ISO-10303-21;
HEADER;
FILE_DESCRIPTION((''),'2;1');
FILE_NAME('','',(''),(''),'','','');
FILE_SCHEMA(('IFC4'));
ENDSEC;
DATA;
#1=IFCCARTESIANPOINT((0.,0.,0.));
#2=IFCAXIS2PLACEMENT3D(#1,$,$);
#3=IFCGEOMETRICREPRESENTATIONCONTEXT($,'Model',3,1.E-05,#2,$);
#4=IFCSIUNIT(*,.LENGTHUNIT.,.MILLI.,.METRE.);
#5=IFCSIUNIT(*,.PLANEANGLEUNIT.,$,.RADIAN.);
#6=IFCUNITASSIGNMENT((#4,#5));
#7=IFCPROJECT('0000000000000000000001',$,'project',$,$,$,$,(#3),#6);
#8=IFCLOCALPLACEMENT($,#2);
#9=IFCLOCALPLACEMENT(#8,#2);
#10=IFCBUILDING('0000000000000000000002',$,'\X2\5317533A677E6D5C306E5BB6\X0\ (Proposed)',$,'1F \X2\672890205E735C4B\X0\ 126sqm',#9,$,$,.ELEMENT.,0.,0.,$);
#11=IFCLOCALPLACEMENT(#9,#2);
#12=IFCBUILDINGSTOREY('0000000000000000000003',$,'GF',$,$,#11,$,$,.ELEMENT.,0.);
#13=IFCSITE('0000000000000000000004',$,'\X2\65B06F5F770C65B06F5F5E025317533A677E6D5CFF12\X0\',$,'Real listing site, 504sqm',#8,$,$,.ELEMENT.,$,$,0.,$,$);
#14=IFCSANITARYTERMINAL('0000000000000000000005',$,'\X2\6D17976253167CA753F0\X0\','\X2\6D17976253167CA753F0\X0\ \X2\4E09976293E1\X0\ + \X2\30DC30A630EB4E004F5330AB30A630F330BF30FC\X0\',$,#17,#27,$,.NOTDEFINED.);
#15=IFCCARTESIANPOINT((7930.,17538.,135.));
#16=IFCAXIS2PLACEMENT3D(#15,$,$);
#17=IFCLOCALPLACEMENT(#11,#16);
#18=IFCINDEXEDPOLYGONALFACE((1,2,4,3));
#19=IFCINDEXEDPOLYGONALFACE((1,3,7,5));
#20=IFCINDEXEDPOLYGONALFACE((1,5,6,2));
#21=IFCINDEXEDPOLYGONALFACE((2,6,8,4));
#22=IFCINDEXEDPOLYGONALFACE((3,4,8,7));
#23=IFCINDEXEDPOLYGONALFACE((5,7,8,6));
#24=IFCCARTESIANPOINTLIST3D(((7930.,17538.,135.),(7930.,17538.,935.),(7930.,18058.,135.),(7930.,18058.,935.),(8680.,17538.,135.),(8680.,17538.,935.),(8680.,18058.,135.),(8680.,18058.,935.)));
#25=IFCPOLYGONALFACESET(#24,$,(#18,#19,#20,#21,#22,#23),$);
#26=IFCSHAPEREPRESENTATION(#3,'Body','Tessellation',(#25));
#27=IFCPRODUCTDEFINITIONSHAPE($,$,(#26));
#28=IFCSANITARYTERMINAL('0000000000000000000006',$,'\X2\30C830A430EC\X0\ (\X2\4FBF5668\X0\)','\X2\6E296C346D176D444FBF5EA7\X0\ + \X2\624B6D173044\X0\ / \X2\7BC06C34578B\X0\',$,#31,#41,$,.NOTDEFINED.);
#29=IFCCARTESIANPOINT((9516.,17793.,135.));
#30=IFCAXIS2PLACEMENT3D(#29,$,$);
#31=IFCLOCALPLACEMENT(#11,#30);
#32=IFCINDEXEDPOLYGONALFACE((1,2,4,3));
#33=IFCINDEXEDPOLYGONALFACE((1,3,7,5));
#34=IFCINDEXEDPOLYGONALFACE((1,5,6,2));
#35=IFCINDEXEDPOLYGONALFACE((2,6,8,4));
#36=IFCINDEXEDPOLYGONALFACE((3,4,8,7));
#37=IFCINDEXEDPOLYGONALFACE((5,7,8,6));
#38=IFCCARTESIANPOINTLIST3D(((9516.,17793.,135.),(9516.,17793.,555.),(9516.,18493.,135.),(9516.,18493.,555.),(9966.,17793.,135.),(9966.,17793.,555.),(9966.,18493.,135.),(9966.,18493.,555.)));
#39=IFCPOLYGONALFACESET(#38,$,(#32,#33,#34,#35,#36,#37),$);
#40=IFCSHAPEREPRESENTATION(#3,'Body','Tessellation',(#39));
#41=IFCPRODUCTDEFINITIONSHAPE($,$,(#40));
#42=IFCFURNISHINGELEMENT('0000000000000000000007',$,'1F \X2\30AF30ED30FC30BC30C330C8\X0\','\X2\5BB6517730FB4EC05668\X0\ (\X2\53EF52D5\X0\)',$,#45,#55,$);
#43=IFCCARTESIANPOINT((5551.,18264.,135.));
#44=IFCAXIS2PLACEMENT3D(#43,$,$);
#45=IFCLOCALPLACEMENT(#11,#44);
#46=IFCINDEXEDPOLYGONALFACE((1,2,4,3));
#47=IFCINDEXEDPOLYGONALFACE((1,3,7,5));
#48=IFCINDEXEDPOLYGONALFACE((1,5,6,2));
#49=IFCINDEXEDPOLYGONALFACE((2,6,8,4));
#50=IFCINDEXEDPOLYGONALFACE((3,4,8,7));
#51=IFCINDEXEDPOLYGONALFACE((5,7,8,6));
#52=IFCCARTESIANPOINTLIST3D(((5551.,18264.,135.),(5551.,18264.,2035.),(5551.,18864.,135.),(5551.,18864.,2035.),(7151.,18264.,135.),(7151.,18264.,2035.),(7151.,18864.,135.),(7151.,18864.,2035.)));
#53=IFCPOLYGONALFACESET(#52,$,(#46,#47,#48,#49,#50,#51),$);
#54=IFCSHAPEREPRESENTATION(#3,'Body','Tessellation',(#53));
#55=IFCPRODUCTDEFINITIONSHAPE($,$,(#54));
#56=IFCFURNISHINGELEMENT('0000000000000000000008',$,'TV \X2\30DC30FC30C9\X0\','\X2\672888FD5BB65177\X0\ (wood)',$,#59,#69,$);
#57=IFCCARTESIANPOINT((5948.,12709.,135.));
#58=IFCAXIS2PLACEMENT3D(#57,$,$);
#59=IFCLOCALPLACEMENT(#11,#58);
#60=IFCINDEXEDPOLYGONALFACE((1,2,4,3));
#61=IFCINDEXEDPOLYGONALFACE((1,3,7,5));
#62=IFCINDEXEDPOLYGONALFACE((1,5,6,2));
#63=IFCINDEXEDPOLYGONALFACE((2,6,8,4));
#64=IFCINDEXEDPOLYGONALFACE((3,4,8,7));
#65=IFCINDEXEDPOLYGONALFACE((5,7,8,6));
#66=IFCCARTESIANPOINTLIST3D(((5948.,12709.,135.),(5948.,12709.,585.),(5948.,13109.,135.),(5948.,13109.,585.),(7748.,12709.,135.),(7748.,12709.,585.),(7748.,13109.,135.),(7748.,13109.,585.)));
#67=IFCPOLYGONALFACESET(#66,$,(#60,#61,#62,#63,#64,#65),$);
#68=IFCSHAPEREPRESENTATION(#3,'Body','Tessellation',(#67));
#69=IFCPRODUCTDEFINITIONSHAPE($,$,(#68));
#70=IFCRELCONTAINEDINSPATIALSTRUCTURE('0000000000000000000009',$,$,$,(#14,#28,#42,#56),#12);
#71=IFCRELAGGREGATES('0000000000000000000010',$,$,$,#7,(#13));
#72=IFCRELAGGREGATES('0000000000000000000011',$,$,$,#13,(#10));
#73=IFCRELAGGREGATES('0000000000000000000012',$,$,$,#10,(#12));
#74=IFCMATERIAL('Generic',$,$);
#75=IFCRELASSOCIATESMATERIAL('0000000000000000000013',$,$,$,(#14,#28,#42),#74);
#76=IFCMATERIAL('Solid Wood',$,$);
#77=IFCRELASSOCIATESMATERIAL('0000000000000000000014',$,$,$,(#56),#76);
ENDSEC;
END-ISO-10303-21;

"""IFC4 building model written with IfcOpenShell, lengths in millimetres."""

from ifc_helpers import new_model, si_unit, frame, frame_2d, origin, place, context, project, spatial, rectangle, extrude, material, element, save


model = new_model("IFC4")

# Units and contexts
model_context = context("Model", 3, precision=1e-05, world=origin())
ifc_project = project(units=[si_unit("LENGTHUNIT", "METRE", prefix="MILLI"), si_unit("PLANEANGLEUNIT", "RADIAN")], contexts=[model_context])

# Site, building, storey
site_placement = place(None, origin())
site = spatial("IfcSite", under=ifc_project, at=site_placement, Name="新潟県新潟市北区松浜２", ObjectType="Real listing site, 504sqm", CompositionType="ELEMENT", RefElevation=0.0)
building_placement = place(site_placement, origin())
building = spatial("IfcBuilding", under=site, at=building_placement, Name="北区松浜の家 (Proposed)", ObjectType="1F 木造平屋 126sqm", CompositionType="ELEMENT", ElevationOfRefHeight=0.0, ElevationOfTerrain=0.0)
storey_placement = place(building_placement, origin())
storey = spatial("IfcBuildingStorey", under=building, at=storey_placement, Name="GF", CompositionType="ELEMENT", Elevation=0.0)

# Shared definitions
ifc_material_1 = material(Name="Solid Wood")

# Shared definitions
ifc_material_2 = material(Name="Generic")

# Sanitary terminals
sanitary_terminal_1_placement = place(storey_placement, frame((7930.0, 17538.0, 135.0)))
element("IfcSanitaryTerminal", 1, at=sanitary_terminal_1_placement, inside=storey, material=ifc_material_2, Name="洗面化粧台", Description="洗面化粧台 三面鏡 + ボウル一体カウンター", PredefinedType="NOTDEFINED", context=model_context, shape_type="SweptSolid", body=[
    extrude(rectangle(XDim=750.0, YDim=520.0, at=frame_2d((375.0, 260.0))), frame((7930.0, 17538.0, 135.0)), (0.0, 0.0, 1.0), 800.0),
])
sanitary_terminal_2_placement = place(storey_placement, frame((9516.0, 17793.0, 135.0)))
element("IfcSanitaryTerminal", 2, at=sanitary_terminal_2_placement, inside=storey, material=ifc_material_2, Name="トイレ (便器)", Description="温水洗浄便座 + 手洗い / 節水型", PredefinedType="NOTDEFINED", context=model_context, shape_type="SweptSolid", body=[
    extrude(rectangle(XDim=450.0, YDim=700.0, at=frame_2d((225.0, 350.0))), frame((9516.0, 17793.0, 135.0)), (0.0, 0.0, 1.0), 420.0),
])

# Furnishing elements
furnishing_1_placement = place(storey_placement, frame((5551.0, 18264.0, 135.0)))
element("IfcFurnishingElement", 3, at=furnishing_1_placement, inside=storey, material=ifc_material_2, Name="1F クローゼット", Description="家具・什器 (可動)", context=model_context, shape_type="SweptSolid", body=[
    extrude(rectangle(XDim=1600.0, YDim=600.0, at=frame_2d((800.0, 300.0))), frame((5551.0, 18264.0, 135.0)), (0.0, 0.0, 1.0), 1900.0),
])
furnishing_2_placement = place(storey_placement, frame((5948.0, 12709.0, 135.0)))
element("IfcFurnishingElement", 4, at=furnishing_2_placement, inside=storey, material=ifc_material_1, Name="TV ボード", Description="木製家具 (wood)", context=model_context, shape_type="SweptSolid", body=[
    extrude(rectangle(XDim=1800.0, YDim=400.0, at=frame_2d((900.0, 200.0))), frame((5948.0, 12709.0, 135.0)), (0.0, 0.0, 1.0), 450.0),
])

save(model, "model.ifc")
